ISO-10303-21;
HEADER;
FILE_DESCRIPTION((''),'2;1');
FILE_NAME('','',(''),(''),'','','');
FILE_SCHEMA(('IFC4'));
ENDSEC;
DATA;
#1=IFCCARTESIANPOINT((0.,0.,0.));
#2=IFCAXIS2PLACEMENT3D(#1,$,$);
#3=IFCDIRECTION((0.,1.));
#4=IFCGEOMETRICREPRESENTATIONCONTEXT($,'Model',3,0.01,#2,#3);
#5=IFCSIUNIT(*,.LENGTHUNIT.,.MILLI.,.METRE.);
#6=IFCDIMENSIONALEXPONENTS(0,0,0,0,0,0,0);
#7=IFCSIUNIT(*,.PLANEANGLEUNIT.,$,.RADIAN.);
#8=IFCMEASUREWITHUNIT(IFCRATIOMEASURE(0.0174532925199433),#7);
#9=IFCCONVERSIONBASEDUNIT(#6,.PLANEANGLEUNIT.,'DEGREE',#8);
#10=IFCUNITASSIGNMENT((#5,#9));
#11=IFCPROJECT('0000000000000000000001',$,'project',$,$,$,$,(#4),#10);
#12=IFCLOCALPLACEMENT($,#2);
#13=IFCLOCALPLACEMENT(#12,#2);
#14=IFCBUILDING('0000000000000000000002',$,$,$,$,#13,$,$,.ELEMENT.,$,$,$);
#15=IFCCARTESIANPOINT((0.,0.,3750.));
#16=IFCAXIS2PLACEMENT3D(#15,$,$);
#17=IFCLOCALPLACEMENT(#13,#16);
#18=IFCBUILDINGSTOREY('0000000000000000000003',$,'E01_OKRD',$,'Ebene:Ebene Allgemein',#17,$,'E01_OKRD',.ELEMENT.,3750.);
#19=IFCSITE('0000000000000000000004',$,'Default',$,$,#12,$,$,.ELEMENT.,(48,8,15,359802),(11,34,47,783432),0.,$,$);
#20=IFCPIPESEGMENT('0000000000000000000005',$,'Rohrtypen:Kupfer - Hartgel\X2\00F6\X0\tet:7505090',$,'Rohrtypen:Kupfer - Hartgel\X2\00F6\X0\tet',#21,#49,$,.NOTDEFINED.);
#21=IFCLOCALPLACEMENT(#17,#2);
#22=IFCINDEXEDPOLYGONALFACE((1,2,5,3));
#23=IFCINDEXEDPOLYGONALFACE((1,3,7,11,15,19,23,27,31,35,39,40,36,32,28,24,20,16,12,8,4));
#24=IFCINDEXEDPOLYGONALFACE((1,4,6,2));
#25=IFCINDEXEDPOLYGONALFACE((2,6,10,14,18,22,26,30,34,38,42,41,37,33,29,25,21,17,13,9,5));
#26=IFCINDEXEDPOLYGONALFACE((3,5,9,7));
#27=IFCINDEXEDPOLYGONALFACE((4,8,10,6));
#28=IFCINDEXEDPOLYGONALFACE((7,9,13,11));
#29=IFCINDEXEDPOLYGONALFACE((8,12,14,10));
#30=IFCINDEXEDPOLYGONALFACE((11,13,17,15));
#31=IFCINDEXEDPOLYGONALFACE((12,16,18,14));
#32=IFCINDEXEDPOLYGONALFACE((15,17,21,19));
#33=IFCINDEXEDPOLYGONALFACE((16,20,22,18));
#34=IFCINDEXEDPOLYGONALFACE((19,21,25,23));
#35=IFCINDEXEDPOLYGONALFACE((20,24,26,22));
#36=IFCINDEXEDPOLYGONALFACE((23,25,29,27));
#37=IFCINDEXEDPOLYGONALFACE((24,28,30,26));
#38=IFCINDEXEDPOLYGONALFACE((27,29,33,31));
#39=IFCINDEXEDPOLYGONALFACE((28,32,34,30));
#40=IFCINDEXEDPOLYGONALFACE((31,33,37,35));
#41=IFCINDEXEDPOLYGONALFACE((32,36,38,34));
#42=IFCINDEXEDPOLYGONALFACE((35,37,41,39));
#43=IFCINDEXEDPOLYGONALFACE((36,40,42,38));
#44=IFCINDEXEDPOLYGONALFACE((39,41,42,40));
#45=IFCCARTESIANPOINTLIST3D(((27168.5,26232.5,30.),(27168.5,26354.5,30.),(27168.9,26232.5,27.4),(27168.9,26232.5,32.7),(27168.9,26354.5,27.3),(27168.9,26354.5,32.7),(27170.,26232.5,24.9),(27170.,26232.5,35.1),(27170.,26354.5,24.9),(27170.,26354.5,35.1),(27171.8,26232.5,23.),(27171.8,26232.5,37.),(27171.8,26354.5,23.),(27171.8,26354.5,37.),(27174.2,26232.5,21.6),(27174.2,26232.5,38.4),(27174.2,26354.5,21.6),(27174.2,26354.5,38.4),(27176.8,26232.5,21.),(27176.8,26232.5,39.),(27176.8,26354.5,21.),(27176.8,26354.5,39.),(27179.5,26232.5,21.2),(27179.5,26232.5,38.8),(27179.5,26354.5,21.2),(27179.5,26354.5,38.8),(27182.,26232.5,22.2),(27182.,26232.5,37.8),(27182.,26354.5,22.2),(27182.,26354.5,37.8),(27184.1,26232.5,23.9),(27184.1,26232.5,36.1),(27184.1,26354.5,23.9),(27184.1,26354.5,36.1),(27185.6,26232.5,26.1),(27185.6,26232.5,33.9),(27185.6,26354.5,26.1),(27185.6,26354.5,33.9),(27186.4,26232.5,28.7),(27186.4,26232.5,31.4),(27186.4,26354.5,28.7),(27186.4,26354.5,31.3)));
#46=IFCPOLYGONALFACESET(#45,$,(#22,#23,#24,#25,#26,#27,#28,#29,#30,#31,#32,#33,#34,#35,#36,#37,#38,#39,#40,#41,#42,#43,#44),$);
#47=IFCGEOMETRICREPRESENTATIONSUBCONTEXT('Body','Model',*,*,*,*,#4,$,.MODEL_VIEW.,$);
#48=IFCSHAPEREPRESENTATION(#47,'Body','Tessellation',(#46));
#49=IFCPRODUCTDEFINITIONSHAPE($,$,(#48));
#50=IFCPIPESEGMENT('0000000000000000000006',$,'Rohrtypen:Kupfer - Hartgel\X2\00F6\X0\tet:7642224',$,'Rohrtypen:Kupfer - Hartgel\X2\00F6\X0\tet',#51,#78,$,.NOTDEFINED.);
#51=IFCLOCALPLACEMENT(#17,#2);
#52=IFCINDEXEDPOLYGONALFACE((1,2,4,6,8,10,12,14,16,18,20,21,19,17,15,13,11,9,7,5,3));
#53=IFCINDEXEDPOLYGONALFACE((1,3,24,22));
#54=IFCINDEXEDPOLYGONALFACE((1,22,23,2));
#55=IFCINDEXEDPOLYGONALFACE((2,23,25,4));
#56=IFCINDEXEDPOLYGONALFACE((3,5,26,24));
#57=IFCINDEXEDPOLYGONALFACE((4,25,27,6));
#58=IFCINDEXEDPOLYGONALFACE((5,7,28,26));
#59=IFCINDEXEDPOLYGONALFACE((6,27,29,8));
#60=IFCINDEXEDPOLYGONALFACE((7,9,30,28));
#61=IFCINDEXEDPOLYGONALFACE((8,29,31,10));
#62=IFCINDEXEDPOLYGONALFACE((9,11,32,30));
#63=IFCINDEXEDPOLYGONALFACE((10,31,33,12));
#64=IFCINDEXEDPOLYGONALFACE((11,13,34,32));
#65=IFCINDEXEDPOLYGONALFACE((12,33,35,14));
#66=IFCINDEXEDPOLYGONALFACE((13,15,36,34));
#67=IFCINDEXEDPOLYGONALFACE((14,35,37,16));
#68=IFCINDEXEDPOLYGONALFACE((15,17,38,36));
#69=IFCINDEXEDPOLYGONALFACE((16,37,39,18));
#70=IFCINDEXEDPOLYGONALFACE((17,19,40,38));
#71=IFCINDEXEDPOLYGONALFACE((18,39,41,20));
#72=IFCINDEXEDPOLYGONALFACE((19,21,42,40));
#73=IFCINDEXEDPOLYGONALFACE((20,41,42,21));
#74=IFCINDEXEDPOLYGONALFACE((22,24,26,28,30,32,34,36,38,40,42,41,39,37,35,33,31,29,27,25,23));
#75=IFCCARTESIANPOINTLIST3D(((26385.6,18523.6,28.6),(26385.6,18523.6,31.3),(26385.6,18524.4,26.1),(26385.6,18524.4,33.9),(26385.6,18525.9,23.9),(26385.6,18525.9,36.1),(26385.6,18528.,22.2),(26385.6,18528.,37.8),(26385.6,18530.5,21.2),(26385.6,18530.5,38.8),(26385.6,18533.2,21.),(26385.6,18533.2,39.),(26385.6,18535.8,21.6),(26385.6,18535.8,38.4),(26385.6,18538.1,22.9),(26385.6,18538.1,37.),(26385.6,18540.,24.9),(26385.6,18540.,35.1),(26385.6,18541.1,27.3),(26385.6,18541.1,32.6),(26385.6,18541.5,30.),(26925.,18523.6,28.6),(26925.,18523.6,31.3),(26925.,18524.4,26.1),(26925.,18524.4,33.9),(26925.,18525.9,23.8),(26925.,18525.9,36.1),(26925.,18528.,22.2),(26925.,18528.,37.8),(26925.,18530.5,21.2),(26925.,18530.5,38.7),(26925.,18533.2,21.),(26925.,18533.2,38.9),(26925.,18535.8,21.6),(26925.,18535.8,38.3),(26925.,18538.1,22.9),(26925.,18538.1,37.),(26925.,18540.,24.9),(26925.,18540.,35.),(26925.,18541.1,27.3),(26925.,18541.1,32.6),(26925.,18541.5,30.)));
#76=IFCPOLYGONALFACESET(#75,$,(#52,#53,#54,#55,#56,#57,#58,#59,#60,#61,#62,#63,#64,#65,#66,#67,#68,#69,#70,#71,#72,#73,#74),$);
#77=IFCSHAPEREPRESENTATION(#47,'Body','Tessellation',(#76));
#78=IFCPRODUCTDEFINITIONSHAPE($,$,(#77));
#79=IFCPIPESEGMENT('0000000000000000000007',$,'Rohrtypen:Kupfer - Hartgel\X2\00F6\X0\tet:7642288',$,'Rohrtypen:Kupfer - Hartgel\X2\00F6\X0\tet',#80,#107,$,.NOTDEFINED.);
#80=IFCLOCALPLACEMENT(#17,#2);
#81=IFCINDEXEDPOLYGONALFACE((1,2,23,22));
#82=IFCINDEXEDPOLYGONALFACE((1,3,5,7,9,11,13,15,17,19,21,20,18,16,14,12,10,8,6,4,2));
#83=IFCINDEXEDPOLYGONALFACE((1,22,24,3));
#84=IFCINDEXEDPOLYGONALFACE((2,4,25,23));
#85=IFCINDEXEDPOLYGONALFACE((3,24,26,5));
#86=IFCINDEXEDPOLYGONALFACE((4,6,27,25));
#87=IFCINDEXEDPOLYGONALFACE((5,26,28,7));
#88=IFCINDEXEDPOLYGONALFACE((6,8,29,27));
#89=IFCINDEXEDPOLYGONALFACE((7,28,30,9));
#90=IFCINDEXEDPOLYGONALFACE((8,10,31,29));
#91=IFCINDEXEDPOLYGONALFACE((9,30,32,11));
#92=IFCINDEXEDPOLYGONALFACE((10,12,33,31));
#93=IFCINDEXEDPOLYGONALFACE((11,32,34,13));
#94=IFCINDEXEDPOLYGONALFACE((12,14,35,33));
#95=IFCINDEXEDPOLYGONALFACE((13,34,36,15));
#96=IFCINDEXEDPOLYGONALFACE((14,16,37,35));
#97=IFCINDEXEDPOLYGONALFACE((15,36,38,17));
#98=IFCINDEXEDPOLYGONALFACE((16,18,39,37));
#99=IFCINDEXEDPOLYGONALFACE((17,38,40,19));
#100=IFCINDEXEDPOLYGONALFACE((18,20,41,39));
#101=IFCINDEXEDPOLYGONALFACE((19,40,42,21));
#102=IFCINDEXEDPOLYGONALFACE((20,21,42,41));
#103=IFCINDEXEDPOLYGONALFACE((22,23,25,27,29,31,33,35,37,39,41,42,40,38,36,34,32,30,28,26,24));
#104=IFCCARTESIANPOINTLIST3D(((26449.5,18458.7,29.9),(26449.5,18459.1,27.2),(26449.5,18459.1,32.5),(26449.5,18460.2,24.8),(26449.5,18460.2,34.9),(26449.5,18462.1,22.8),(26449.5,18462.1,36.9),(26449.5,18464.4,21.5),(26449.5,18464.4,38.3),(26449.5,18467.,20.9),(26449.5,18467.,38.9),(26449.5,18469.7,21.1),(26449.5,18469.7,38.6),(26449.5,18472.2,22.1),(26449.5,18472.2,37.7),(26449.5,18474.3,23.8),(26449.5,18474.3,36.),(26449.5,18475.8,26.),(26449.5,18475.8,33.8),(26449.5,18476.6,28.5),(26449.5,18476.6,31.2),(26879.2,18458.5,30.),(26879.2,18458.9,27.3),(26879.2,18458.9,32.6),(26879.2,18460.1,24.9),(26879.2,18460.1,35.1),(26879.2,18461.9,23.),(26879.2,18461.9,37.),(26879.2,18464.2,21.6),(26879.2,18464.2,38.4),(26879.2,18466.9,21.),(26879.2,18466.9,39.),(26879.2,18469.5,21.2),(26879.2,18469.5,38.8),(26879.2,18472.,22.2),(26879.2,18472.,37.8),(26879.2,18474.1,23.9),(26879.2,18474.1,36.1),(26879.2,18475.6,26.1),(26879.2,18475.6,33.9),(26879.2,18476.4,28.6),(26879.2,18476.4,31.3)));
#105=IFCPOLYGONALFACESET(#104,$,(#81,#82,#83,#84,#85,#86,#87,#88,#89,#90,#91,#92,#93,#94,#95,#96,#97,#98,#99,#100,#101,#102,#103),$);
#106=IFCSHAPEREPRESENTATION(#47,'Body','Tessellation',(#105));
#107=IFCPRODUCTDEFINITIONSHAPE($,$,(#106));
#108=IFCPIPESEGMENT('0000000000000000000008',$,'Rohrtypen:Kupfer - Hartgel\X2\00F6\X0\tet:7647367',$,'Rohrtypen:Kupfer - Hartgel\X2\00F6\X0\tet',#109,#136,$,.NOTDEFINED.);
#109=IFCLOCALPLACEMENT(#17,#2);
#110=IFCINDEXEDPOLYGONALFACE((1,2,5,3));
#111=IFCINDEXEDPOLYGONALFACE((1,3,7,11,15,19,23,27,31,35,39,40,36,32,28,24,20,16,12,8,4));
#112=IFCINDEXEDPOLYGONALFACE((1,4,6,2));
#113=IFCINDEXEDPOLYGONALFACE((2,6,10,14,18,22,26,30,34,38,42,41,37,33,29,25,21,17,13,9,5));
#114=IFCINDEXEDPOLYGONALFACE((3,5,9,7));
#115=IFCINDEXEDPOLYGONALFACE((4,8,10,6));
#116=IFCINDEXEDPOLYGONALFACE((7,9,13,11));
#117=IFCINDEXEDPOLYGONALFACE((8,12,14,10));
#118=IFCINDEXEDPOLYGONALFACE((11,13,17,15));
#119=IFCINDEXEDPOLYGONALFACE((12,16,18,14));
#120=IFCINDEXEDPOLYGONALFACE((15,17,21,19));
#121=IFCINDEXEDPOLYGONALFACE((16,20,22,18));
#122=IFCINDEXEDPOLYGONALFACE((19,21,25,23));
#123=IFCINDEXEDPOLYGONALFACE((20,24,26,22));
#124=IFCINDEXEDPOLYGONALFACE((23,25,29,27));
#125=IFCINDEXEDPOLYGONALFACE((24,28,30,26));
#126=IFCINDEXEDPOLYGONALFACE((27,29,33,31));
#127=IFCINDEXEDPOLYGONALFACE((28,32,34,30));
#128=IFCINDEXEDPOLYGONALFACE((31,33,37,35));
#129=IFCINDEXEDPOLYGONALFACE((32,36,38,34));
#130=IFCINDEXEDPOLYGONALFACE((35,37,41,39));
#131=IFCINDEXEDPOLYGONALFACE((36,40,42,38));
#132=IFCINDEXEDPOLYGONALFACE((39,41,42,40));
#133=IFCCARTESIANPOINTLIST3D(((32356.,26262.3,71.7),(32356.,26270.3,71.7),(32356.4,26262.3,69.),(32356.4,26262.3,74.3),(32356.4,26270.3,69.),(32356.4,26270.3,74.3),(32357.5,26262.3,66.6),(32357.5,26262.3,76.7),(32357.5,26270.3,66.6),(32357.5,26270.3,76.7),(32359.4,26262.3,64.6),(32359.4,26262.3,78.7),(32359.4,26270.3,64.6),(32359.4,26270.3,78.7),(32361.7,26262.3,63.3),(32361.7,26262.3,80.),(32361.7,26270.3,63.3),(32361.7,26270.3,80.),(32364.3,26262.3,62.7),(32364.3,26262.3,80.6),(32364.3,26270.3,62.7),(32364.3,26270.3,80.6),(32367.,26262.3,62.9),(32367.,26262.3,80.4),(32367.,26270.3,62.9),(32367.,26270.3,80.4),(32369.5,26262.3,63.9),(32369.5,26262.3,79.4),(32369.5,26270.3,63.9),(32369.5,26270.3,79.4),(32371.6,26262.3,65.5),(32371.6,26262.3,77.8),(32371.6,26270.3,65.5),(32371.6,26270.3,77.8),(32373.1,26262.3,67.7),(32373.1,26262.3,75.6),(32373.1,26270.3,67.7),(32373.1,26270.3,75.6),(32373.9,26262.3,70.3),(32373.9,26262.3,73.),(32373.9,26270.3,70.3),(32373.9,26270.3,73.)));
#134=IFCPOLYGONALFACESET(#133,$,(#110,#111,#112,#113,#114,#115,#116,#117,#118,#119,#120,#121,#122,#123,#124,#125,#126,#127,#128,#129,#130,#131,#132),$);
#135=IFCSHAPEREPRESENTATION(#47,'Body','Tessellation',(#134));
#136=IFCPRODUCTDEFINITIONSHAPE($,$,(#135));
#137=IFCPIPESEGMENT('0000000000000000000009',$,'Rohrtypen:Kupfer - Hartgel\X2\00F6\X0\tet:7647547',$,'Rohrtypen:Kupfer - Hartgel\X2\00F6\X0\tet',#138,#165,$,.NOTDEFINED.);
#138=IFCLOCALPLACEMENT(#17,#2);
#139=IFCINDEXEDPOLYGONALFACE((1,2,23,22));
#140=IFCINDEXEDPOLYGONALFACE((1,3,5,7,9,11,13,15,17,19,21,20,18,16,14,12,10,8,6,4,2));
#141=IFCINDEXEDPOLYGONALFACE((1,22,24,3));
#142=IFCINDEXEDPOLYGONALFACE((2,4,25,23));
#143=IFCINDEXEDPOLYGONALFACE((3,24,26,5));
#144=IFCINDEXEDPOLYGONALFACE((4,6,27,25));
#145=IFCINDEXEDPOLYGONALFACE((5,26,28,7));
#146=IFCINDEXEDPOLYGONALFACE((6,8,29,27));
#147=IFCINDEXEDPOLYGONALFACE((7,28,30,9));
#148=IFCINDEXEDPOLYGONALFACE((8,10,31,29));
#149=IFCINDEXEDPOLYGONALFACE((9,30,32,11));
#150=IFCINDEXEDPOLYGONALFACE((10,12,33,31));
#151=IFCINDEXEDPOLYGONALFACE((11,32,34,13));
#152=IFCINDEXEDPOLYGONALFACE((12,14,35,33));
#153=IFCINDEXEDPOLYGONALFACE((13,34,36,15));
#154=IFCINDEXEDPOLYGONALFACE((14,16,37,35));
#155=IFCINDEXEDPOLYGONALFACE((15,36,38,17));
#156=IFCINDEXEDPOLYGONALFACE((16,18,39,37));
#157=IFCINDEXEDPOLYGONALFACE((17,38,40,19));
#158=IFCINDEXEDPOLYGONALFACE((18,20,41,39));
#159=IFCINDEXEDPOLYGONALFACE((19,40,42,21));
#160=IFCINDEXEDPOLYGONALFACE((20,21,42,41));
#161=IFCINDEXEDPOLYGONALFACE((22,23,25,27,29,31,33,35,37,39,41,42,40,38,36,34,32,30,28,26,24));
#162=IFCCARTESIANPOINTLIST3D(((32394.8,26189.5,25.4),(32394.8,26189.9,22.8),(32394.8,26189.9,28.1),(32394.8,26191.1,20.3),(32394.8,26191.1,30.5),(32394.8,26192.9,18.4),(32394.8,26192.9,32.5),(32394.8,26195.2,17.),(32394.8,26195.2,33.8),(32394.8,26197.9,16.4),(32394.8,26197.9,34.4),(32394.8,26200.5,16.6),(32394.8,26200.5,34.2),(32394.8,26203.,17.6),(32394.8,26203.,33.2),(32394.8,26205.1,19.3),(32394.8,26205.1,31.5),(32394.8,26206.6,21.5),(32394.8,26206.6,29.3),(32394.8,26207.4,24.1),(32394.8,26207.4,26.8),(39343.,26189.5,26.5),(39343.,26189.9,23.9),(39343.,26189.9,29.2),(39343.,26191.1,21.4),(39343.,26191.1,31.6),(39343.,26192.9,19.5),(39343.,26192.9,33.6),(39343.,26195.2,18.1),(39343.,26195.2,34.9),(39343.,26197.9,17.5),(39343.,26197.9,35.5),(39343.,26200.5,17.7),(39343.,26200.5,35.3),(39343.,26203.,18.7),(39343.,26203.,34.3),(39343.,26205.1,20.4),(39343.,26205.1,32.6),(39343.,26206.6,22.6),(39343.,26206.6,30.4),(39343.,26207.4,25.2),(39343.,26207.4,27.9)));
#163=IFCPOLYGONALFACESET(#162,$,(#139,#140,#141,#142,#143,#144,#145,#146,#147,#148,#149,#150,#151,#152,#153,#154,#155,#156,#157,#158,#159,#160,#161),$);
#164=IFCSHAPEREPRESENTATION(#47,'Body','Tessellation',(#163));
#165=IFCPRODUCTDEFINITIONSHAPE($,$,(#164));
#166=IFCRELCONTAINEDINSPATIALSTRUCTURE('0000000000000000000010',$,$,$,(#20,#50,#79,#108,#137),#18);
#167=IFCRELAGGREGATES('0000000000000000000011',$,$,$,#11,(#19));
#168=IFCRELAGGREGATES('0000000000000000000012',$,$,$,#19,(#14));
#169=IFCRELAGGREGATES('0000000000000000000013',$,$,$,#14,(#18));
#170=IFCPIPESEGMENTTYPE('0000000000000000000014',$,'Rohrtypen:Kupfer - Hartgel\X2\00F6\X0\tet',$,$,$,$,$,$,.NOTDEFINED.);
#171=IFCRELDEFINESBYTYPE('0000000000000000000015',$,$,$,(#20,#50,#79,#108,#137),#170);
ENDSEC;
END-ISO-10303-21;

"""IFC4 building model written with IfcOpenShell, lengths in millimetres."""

from ifc_helpers import new_model, entity, si_unit, converted_unit, direction, frame, frame_2d, origin, origin_2d_with_axis, place, context, subcontext, project, spatial, circle, extrude, type_object, element, save


model = new_model("IFC4")

# Units and contexts
model_context = context("Model", 3, precision=0.01, world=origin(), true_north=direction((0.0, 1.0)))
body_context = subcontext(model_context, "Body", "Model", "MODEL_VIEW")
ifc_project = project(units=[si_unit("LENGTHUNIT", "METRE", prefix="MILLI"), converted_unit("PLANEANGLEUNIT", "DEGREE", entity("IfcRatioMeasure", 0.0174532925199433), si_unit("PLANEANGLEUNIT", "RADIAN"), dimensions=[0, 0, 0, 0, 0, 0, 0])], contexts=[model_context])

# Site, building, storey
site_placement = place(None, origin())
site = spatial("IfcSite", under=ifc_project, at=site_placement, Name="Default", CompositionType="ELEMENT", RefLatitude=(48, 8, 15, 359802), RefLongitude=(11, 34, 47, 783432), RefElevation=0.0)
building_placement = place(site_placement, origin())
building = spatial("IfcBuilding", under=site, at=building_placement, CompositionType="ELEMENT")
storey_placement = place(building_placement, frame((0.0, 0.0, 3750.0)))
storey = spatial("IfcBuildingStorey", under=building, at=storey_placement, Name="E01_OKRD", ObjectType="Ebene:Ebene Allgemein", LongName="E01_OKRD", CompositionType="ELEMENT", Elevation=3750.0)

# Pipe segments
pipe_segment_type = type_object("IfcPipeSegmentType", Name="Rohrtypen:Kupfer - Hartgelötet", PredefinedType="NOTDEFINED")
pipe_segment_1_placement = place(storey_placement, frame((27166.9, 26232.5, 19.4)))
element("IfcPipeSegment", 1, at=pipe_segment_1_placement, inside=storey, type_object=pipe_segment_type, Name="Rohrtypen:Kupfer - Hartgelötet:7505090", ObjectType="Rohrtypen:Kupfer - Hartgelötet", PredefinedType="NOTDEFINED", context=body_context, shape_type="SweptSolid", body=[
    extrude(circle(Radius=9.0, at=origin_2d_with_axis()), frame((10.6, 0.0, 10.6), z_axis=(0.0, 1.0, -0.000093), x_axis=(-1.0, 0.0, 0.0)), (0.0, 0.0, 1.0), 122.0),
])
pipe_segment_2_placement = place(storey_placement, frame((26385.6, 18521.9, 19.4)))
element("IfcPipeSegment", 2, at=pipe_segment_2_placement, inside=storey, type_object=pipe_segment_type, Name="Rohrtypen:Kupfer - Hartgelötet:7642224", ObjectType="Rohrtypen:Kupfer - Hartgelötet", PredefinedType="NOTDEFINED", context=body_context, shape_type="SweptSolid", body=[
    extrude(circle(Radius=9.0, at=origin_2d_with_axis()), frame((539.4, 10.6, 10.6), z_axis=(-1.0, 0.0, 0.000029), x_axis=(0.0, 1.0, 0.0)), (0.0, 0.0, 1.0), 539.4),
])
pipe_segment_3_placement = place(storey_placement, frame((26449.5, 18456.9, 19.3)))
element("IfcPipeSegment", 3, at=pipe_segment_3_placement, inside=storey, type_object=pipe_segment_type, Name="Rohrtypen:Kupfer - Hartgelötet:7642288", ObjectType="Rohrtypen:Kupfer - Hartgelötet", PredefinedType="NOTDEFINED", context=body_context, shape_type="SweptSolid", body=[
    extrude(circle(Radius=9.0, at=frame_2d((0.0, 0.0), x_axis=(1.0, 0.0))), frame((0.0, 10.7, 10.6), z_axis=(1.0, -0.000302, 0.000269), x_axis=(-0.000302, -1.0, 0.0)), (0.0, 0.0, 1.0), 429.7),
])
pipe_segment_4_placement = place(storey_placement, frame((32354.4, 26262.3, 61.1)))
element("IfcPipeSegment", 4, at=pipe_segment_4_placement, inside=storey, type_object=pipe_segment_type, Name="Rohrtypen:Kupfer - Hartgelötet:7647367", ObjectType="Rohrtypen:Kupfer - Hartgelötet", PredefinedType="NOTDEFINED", context=body_context, shape_type="SweptSolid", body=[
    extrude(circle(Radius=9.0, at=origin_2d_with_axis()), frame((10.6, 8.0, 10.6), z_axis=(0.000049, -1.0, 0.0), x_axis=(-1.0, -0.000049, 0.0)), (0.0, 0.0, 1.0), 8.0),
])
pipe_segment_5_placement = place(storey_placement, frame((32394.8, 26187.9, 14.8)))
element("IfcPipeSegment", 5, at=pipe_segment_5_placement, inside=storey, type_object=pipe_segment_type, Name="Rohrtypen:Kupfer - Hartgelötet:7647547", ObjectType="Rohrtypen:Kupfer - Hartgelötet", PredefinedType="NOTDEFINED", context=body_context, shape_type="SweptSolid", body=[
    extrude(circle(Radius=9.0, at=frame_2d((0.0, 0.0), x_axis=(1.0, 0.0))), frame((0.0, 10.6, 10.6), z_axis=(1.0, 0.0, 0.000158), x_axis=(0.0, -1.0, 0.0)), (0.0, 0.0, 1.0), 6948.2),
])

save(model, "model.ifc")
